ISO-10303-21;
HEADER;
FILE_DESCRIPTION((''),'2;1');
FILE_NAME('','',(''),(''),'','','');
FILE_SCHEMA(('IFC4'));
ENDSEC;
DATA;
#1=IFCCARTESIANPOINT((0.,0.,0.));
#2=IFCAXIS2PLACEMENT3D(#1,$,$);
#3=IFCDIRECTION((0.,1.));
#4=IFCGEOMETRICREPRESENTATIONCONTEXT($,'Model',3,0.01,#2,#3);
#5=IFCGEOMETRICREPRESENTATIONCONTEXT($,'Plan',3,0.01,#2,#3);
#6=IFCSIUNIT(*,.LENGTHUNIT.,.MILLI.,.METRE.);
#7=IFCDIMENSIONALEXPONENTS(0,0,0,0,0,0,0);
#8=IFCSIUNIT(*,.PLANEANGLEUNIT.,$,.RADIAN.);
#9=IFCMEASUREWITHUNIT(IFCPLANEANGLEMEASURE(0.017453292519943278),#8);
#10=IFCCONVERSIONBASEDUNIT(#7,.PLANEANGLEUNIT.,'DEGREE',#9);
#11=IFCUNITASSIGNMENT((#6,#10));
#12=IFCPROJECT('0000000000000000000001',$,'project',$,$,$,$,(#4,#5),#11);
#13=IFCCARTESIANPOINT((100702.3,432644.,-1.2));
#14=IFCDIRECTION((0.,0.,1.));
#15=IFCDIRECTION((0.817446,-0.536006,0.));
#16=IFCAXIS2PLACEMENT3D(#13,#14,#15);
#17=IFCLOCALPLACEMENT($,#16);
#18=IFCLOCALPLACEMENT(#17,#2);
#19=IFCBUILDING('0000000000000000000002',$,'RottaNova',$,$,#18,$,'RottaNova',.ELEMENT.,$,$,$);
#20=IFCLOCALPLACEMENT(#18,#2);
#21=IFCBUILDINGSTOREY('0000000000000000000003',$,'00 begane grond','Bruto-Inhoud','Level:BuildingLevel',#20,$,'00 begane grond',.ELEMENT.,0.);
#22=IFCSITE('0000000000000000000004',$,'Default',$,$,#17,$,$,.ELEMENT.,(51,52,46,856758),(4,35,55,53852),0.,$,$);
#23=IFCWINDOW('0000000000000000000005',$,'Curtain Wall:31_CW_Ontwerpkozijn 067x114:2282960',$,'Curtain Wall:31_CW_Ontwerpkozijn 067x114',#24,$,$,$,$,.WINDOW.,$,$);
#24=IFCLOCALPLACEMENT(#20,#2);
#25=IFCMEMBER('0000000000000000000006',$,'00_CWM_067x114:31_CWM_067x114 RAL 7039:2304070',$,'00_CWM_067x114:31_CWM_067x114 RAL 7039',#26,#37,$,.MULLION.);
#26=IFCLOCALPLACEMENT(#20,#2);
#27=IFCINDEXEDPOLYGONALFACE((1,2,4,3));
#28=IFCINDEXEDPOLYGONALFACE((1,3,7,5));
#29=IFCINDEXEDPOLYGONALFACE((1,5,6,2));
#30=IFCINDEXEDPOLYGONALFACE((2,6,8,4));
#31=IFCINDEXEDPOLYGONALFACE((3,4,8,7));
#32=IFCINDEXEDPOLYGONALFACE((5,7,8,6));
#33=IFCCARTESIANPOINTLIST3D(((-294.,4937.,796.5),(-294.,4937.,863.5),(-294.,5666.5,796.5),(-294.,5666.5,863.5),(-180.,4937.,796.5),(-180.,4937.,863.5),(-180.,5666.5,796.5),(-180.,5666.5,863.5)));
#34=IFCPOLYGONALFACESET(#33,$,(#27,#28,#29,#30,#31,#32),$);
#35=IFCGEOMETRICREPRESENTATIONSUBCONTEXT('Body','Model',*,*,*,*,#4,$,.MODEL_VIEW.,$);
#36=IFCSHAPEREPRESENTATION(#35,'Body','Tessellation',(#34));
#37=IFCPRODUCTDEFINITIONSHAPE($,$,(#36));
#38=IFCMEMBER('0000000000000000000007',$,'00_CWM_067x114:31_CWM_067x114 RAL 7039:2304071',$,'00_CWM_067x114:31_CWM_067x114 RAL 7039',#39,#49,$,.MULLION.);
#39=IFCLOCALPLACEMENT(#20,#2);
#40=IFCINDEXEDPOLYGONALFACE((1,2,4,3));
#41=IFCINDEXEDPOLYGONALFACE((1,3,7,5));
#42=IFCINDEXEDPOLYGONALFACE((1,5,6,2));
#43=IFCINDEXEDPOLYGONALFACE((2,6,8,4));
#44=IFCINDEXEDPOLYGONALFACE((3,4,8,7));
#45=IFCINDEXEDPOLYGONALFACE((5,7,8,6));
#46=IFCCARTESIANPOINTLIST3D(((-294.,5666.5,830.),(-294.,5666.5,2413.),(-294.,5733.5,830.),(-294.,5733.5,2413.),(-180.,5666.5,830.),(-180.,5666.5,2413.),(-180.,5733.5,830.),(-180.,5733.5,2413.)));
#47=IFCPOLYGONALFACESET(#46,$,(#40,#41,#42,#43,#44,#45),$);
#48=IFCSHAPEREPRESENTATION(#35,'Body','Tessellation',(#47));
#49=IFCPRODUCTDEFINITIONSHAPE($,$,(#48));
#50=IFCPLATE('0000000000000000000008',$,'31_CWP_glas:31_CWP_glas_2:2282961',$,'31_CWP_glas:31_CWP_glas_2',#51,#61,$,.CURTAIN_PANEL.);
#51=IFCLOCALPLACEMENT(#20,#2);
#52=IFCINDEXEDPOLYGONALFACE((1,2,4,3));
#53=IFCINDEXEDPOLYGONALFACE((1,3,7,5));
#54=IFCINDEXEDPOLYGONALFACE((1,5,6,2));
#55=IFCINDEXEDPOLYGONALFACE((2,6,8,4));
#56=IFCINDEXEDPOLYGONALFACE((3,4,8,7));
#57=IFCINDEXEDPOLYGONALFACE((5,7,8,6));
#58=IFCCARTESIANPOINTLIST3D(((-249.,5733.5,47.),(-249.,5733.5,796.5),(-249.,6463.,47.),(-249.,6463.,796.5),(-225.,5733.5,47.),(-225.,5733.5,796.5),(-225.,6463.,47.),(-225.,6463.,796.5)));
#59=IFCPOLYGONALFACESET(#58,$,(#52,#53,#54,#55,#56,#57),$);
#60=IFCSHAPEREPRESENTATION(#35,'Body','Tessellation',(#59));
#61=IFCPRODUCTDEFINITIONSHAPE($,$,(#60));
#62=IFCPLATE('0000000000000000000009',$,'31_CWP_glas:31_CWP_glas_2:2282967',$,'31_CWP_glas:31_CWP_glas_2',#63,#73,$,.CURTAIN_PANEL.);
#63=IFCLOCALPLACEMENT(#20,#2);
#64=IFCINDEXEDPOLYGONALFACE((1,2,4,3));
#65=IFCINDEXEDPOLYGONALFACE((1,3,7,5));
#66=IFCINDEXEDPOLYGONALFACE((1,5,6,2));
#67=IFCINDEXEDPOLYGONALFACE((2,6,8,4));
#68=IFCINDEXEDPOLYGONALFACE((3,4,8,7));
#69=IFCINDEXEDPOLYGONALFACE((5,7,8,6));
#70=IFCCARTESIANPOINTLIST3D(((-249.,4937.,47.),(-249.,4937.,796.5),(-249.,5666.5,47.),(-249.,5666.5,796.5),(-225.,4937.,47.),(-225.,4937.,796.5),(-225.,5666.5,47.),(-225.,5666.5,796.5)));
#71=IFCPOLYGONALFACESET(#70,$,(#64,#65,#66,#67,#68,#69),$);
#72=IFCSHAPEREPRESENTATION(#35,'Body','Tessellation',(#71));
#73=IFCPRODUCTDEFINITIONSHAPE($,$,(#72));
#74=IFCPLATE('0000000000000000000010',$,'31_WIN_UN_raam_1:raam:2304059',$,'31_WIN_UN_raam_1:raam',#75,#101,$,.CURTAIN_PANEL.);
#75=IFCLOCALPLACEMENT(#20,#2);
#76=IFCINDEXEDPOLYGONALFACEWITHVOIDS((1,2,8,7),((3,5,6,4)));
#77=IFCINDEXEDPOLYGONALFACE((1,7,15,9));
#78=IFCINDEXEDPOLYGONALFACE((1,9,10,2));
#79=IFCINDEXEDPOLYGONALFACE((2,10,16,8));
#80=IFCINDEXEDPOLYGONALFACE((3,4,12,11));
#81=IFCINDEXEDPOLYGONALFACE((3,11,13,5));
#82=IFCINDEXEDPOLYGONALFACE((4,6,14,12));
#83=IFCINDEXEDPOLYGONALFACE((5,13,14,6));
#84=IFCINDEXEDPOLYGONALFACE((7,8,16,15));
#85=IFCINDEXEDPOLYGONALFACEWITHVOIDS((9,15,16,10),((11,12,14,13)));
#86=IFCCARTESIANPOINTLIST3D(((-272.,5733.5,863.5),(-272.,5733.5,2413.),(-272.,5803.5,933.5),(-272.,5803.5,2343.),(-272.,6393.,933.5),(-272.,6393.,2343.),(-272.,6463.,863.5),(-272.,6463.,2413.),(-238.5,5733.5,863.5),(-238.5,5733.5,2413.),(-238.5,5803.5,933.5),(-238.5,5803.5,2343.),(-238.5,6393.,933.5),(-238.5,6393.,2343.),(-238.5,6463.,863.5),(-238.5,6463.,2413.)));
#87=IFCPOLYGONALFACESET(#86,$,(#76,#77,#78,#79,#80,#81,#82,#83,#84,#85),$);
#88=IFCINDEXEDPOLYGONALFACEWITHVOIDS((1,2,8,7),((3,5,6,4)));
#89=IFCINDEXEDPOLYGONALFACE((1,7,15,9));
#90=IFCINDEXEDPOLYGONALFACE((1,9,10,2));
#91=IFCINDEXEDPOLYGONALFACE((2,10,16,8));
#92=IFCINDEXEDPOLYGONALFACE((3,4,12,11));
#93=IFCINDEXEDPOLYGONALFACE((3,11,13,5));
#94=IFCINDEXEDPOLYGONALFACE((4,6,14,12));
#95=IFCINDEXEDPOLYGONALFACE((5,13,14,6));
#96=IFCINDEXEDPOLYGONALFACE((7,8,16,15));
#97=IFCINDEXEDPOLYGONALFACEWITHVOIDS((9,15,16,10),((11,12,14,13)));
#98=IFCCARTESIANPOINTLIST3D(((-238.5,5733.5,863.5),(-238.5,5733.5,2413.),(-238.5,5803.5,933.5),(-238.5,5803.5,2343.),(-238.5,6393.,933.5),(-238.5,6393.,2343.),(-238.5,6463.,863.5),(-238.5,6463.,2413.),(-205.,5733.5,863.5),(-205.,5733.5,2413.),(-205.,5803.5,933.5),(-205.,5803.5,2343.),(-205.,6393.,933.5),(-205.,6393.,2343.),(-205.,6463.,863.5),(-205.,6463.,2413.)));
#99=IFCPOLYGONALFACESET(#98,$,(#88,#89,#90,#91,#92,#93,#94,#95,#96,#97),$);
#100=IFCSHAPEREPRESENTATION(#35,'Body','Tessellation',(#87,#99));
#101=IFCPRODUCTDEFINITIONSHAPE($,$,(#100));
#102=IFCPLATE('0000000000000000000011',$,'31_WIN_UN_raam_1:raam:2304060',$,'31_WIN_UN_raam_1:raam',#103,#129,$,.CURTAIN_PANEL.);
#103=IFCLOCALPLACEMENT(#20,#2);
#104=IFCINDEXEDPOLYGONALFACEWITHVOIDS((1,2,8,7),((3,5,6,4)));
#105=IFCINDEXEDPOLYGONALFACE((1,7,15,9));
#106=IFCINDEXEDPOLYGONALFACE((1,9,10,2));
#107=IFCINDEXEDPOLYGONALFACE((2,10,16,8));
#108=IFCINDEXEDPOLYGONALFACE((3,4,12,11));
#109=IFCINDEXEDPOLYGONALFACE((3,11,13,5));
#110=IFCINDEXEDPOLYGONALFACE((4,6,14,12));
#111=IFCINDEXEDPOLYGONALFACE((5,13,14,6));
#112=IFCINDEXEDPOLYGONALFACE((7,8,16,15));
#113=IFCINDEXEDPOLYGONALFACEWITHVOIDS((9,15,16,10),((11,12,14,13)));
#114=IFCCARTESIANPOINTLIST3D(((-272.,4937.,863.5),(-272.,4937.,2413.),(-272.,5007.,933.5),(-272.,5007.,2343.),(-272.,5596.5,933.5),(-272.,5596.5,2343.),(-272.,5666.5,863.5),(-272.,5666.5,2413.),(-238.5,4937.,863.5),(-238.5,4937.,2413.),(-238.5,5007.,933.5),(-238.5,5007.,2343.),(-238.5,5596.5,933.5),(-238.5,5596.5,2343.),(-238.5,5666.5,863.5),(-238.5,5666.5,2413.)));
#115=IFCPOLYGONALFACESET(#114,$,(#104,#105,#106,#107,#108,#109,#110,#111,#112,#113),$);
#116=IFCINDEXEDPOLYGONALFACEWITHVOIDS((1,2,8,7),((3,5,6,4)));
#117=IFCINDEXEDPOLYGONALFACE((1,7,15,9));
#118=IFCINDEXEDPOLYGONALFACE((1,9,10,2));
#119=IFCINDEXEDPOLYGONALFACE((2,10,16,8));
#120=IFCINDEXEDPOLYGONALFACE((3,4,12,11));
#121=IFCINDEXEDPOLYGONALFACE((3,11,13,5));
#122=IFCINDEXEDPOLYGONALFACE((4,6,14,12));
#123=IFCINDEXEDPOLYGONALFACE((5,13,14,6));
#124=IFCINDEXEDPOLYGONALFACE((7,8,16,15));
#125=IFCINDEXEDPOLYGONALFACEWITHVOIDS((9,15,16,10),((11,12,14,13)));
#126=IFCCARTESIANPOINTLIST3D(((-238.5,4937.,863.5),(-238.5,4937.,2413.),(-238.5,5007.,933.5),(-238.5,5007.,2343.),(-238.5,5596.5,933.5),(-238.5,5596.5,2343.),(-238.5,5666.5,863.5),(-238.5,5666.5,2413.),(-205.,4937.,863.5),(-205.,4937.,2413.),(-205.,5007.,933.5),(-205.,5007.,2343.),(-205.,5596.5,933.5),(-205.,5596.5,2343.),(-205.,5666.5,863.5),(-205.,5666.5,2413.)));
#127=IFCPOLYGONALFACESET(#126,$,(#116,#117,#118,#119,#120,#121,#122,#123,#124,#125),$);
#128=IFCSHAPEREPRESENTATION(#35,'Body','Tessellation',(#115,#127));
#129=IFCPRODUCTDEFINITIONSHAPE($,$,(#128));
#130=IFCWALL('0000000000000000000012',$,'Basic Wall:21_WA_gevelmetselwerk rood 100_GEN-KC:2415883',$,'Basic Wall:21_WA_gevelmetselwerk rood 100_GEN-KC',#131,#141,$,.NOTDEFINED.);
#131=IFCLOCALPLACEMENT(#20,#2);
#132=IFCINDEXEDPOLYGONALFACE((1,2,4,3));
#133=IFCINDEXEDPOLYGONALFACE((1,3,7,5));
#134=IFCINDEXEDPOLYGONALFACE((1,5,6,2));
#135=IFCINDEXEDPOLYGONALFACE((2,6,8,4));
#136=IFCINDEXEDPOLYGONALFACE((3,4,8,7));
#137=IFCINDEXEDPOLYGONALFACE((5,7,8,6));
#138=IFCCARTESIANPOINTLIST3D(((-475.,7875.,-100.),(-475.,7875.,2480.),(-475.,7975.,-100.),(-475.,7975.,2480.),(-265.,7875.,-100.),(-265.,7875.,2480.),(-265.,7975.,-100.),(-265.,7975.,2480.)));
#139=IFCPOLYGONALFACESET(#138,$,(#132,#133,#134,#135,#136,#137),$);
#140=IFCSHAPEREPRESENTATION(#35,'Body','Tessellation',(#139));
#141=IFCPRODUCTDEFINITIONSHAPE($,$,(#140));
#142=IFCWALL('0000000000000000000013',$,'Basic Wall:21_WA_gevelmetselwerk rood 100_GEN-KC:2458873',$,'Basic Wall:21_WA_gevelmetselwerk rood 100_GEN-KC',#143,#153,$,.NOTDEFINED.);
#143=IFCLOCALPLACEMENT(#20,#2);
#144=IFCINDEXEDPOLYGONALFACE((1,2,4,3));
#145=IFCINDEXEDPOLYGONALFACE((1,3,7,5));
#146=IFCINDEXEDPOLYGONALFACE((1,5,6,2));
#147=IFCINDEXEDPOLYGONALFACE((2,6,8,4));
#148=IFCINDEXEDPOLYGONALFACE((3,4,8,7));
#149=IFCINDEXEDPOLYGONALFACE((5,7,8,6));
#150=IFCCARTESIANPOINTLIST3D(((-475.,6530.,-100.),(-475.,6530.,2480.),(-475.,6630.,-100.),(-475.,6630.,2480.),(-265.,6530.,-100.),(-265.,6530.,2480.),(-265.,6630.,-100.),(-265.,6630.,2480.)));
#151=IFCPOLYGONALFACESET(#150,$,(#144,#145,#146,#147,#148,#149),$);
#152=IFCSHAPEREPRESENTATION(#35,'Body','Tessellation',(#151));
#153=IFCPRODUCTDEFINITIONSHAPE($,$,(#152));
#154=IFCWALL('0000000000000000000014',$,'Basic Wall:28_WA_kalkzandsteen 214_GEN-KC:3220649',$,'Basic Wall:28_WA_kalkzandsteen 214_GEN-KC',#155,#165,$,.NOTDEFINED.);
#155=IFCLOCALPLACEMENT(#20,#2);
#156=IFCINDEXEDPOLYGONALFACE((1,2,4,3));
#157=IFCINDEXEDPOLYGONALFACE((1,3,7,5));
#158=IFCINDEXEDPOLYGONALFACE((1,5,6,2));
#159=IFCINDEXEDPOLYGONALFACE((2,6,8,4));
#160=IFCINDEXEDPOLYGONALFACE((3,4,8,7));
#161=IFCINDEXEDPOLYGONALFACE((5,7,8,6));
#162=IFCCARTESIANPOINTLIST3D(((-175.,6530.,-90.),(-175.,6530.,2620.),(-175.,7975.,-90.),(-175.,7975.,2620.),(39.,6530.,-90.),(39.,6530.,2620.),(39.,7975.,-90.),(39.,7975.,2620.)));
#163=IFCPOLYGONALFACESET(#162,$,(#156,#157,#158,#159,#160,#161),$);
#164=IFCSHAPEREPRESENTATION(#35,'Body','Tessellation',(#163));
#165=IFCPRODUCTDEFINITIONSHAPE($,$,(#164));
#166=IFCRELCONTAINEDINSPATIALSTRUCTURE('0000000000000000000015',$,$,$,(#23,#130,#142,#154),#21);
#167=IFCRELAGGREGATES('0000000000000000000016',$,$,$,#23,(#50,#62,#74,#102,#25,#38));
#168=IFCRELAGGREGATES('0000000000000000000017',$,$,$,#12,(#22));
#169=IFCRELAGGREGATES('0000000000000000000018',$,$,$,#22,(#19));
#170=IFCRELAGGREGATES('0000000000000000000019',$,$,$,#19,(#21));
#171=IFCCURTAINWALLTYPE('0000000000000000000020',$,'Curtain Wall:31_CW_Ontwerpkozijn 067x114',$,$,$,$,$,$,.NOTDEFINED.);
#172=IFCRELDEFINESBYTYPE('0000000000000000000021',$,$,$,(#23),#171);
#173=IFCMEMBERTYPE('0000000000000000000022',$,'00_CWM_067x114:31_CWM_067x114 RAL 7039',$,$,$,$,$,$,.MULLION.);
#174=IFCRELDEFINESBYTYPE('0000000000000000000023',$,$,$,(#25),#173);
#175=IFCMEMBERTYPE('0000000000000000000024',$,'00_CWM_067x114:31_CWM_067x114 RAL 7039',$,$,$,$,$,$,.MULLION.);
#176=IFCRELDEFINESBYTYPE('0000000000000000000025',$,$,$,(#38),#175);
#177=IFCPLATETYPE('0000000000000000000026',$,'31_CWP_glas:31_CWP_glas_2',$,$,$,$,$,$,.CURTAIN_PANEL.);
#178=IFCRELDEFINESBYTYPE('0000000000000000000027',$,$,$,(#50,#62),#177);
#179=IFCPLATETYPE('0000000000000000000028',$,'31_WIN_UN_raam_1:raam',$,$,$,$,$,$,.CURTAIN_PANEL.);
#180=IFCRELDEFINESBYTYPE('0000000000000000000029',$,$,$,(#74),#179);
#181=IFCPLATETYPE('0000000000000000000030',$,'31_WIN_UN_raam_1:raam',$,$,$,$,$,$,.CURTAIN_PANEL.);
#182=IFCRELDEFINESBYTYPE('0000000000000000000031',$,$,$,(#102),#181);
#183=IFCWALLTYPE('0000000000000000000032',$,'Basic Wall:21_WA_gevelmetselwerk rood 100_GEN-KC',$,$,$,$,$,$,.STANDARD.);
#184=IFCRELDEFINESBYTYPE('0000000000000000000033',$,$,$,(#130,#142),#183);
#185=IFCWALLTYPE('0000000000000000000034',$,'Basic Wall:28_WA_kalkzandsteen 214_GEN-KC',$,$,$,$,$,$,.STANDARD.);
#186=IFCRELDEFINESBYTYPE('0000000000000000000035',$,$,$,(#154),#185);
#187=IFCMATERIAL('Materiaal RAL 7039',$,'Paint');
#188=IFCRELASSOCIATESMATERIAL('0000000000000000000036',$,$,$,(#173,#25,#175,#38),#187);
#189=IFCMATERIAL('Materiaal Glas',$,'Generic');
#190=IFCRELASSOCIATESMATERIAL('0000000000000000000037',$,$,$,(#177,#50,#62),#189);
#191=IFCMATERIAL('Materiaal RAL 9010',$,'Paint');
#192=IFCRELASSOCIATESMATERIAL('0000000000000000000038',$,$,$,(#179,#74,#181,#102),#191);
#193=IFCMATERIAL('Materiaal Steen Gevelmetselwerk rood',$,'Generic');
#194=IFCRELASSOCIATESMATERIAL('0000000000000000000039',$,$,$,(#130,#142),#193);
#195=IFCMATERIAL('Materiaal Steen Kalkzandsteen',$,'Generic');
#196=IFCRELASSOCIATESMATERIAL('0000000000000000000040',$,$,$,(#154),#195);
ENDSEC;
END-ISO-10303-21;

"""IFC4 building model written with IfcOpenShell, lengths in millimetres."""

from ifc_helpers import new_model, entity, si_unit, converted_unit, direction, frame, origin, place, context, subcontext, project, spatial, indexed_curve, outline, extrude, source, transform, mapped, material, type_object, type_shapes, element, aggregate, save


model = new_model("IFC4")

# Units and contexts
model_context = context("Model", 3, precision=0.01, world=origin(), true_north=direction((0.0, 1.0)))
plan_context = context("Plan", 3, precision=0.01, world=origin(), true_north=direction((0.0, 1.0)))
body_context = subcontext(model_context, "Body", "Model", "MODEL_VIEW")
ifc_project = project(units=[si_unit("LENGTHUNIT", "METRE", prefix="MILLI"), converted_unit("PLANEANGLEUNIT", "DEGREE", entity("IfcPlaneAngleMeasure", 0.017453292519943278), si_unit("PLANEANGLEUNIT", "RADIAN"), dimensions=[0, 0, 0, 0, 0, 0, 0])], contexts=[model_context, plan_context])

# Site, building, storey
site_placement = place(None, frame((100702.3, 432644.0, -1.2), z_axis=(0.0, 0.0, 1.0), x_axis=(0.817446, -0.536006, 0.0)))
site = spatial("IfcSite", under=ifc_project, at=site_placement, Name="Default", CompositionType="ELEMENT", RefLatitude=(51, 52, 46, 856758), RefLongitude=(4, 35, 55, 53852), RefElevation=0.0)
building_placement = place(site_placement, origin())
building = spatial("IfcBuilding", under=site, at=building_placement, Name="RottaNova", LongName="RottaNova", CompositionType="ELEMENT")
storey_placement = place(building_placement, origin())
storey = spatial("IfcBuildingStorey", under=building, at=storey_placement, Name="00 begane grond", Description="Bruto-Inhoud", ObjectType="Level:BuildingLevel", LongName="00 begane grond", CompositionType="ELEMENT", Elevation=0.0)

# Window, members, plates
curtain_wall_type = type_object("IfcCurtainWallType", Name="Curtain Wall:31_CW_Ontwerpkozijn 067x114", PredefinedType="NOTDEFINED")
window_placement = place(storey_placement, origin())
window = element("IfcWindow", 1, at=window_placement, inside=storey, type_object=curtain_wall_type, Name="Curtain Wall:31_CW_Ontwerpkozijn 067x114:2282960", ObjectType="Curtain Wall:31_CW_Ontwerpkozijn 067x114", PredefinedType="WINDOW")
ifc_material_1 = material(Name="Materiaal RAL 7039", Category="Paint")
member_type_1 = type_object("IfcMemberType", Name="00_CWM_067x114:31_CWM_067x114 RAL 7039", PredefinedType="MULLION", material=ifc_material_1)
shared_shape_1 = source(origin(), body_context, "Body", "SweptSolid", [
    extrude(outline(indexed_curve([(-33.5, -57.0), (33.5, -57.0), (33.5, 57.0), (-33.5, 57.0), (-33.5, -57.0)], self_intersect=False)), frame((0.0, 57.0, -729.5), z_axis=(0.0, 0.0, 1.0), x_axis=(-1.0, 0.0, 0.0)), (0.0, 0.0, 1.0), 729.5),
])
type_shapes(member_type_1, [shared_shape_1])
member_1_placement = place(window_placement, frame((-180.0, 4937.0, 830.0), z_axis=(0.0, -1.0, 0.0), x_axis=(0.0, 0.0, 1.0)))
member_1 = element("IfcMember", 2, at=member_1_placement, type_object=member_type_1, material=ifc_material_1, Name="00_CWM_067x114:31_CWM_067x114 RAL 7039:2304070", ObjectType="00_CWM_067x114:31_CWM_067x114 RAL 7039", PredefinedType="MULLION", context=body_context, shape_type="MappedRepresentation", body=[
    mapped(shared_shape_1, transform((0.0, 0.0, 0.0), scale=1.0)),
])
member_type_2 = type_object("IfcMemberType", Name="00_CWM_067x114:31_CWM_067x114 RAL 7039", PredefinedType="MULLION", material=ifc_material_1)
shared_shape_2 = source(origin(), body_context, "Body", "SweptSolid", [
    extrude(outline(indexed_curve([(-33.5, -57.0), (33.5, -57.0), (33.5, 57.0), (-33.5, 57.0), (-33.5, -57.0)], self_intersect=False)), frame((0.0, 57.0, -1583.0), z_axis=(0.0, 0.0, 1.0), x_axis=(-1.0, 0.0, 0.0)), (0.0, 0.0, 1.0), 1583.0),
])
type_shapes(member_type_2, [shared_shape_2])
member_2_placement = place(window_placement, frame((-180.0, 5700.0, 830.0), z_axis=(0.0, 0.0, -1.0), x_axis=(0.0, -1.0, 0.0)))
member_2 = element("IfcMember", 3, at=member_2_placement, type_object=member_type_2, material=ifc_material_1, Name="00_CWM_067x114:31_CWM_067x114 RAL 7039:2304071", ObjectType="00_CWM_067x114:31_CWM_067x114 RAL 7039", PredefinedType="MULLION", context=body_context, shape_type="MappedRepresentation", body=[
    mapped(shared_shape_2, transform((0.0, 0.0, 0.0), scale=1.0)),
])
ifc_material_2 = material(Name="Materiaal Glas", Category="Generic")
plate_type_1 = type_object("IfcPlateType", Name="31_CWP_glas:31_CWP_glas_2", PredefinedType="CURTAIN_PANEL", material=ifc_material_2)
shared_shape_3 = source(origin(), body_context, "Body", "SweptSolid", [
    extrude(outline(indexed_curve([(-12.0, -364.7), (12.0, -364.7), (12.0, 364.7), (-12.0, 364.7), (-12.0, -364.7)], self_intersect=False)), frame((0.0, -57.0, 0.0), z_axis=(0.0, 0.0, 1.0), x_axis=(0.0, 1.0, 0.0)), (0.0, 0.0, 1.0), 749.5),
])
type_shapes(plate_type_1, [shared_shape_3])
plate_1_placement = place(window_placement, frame((-180.0, 6098.2, 47.0), z_axis=(0.0, 0.0, 1.0), x_axis=(0.0, -1.0, 0.0)))
plate_1 = element("IfcPlate", 4, at=plate_1_placement, type_object=plate_type_1, material=ifc_material_2, Name="31_CWP_glas:31_CWP_glas_2:2282961", ObjectType="31_CWP_glas:31_CWP_glas_2", PredefinedType="CURTAIN_PANEL", context=body_context, shape_type="MappedRepresentation", body=[
    mapped(shared_shape_3, transform((0.0, 0.0, 0.0), scale=1.0)),
])
plate_2_placement = place(window_placement, frame((-180.0, 5301.7, 47.0), z_axis=(0.0, 0.0, 1.0), x_axis=(0.0, -1.0, 0.0)))
plate_2 = element("IfcPlate", 5, at=plate_2_placement, type_object=plate_type_1, material=ifc_material_2, Name="31_CWP_glas:31_CWP_glas_2:2282967", ObjectType="31_CWP_glas:31_CWP_glas_2", PredefinedType="CURTAIN_PANEL", context=body_context, shape_type="MappedRepresentation", body=[
    mapped(shared_shape_3, transform((0.0, 0.0, 0.0), scale=1.0)),
])
ifc_material_3 = material(Name="Materiaal RAL 9010", Category="Paint")
plate_type_2 = type_object("IfcPlateType", Name="31_WIN_UN_raam_1:raam", PredefinedType="CURTAIN_PANEL", material=ifc_material_3)
shared_shape_4 = source(origin(), body_context, "Body", "SweptSolid", [
    extrude(outline(indexed_curve([(-364.7, -774.7), (364.7, -774.7), (364.7, 774.7), (-364.7, 774.7), (-364.7, -774.7)], self_intersect=False), holes=[indexed_curve([(-294.7, 704.7), (294.7, 704.7), (294.7, -704.8), (-294.7, -704.8), (-294.7, 704.7)], self_intersect=False)]), frame((0.0, -92.0, 774.8), z_axis=(0.0, 1.0, 0.0), x_axis=(1.0, 0.0, 0.0)), (0.0, 0.0, 1.0), 33.5),
    extrude(outline(indexed_curve([(-364.7, -774.7), (364.7, -774.7), (364.7, 774.7), (-364.7, 774.7), (-364.7, -774.7)], self_intersect=False), holes=[indexed_curve([(-294.7, 704.7), (294.7, 704.7), (294.7, -704.8), (-294.7, -704.8), (-294.7, 704.7)], self_intersect=False)]), frame((0.0, -58.5, 774.8), z_axis=(0.0, 1.0, 0.0), x_axis=(1.0, 0.0, 0.0)), (0.0, 0.0, 1.0), 33.5),
])
type_shapes(plate_type_2, [shared_shape_4])
plate_3_placement = place(window_placement, frame((-180.0, 6098.2, 863.5), z_axis=(0.0, 0.0, 1.0), x_axis=(0.0, -1.0, 0.0)))
plate_3 = element("IfcPlate", 6, at=plate_3_placement, type_object=plate_type_2, material=ifc_material_3, Name="31_WIN_UN_raam_1:raam:2304059", ObjectType="31_WIN_UN_raam_1:raam", PredefinedType="CURTAIN_PANEL", context=body_context, shape_type="MappedRepresentation", body=[
    mapped(shared_shape_4, transform((0.0, 0.0, 0.0), scale=1.0)),
])
plate_type_3 = type_object("IfcPlateType", Name="31_WIN_UN_raam_1:raam", PredefinedType="CURTAIN_PANEL", material=ifc_material_3)
shared_shape_5 = source(origin(), body_context, "Body", "SweptSolid", [
    extrude(outline(indexed_curve([(-364.7, -774.7), (364.7, -774.7), (364.7, 774.7), (-364.7, 774.7), (-364.7, -774.7)], self_intersect=False), holes=[indexed_curve([(-294.7, 704.7), (294.7, 704.7), (294.7, -704.8), (-294.7, -704.8), (-294.7, 704.7)], self_intersect=False)]), frame((0.0, -92.0, 774.8), z_axis=(0.0, 1.0, 0.0), x_axis=(1.0, 0.0, 0.0)), (0.0, 0.0, 1.0), 33.5),
    extrude(outline(indexed_curve([(-364.7, -774.7), (364.7, -774.7), (364.7, 774.7), (-364.7, 774.7), (-364.7, -774.7)], self_intersect=False), holes=[indexed_curve([(-294.7, 704.7), (294.7, 704.7), (294.7, -704.8), (-294.7, -704.8), (-294.7, 704.7)], self_intersect=False)]), frame((0.0, -58.5, 774.8), z_axis=(0.0, 1.0, 0.0), x_axis=(1.0, 0.0, 0.0)), (0.0, 0.0, 1.0), 33.5),
])
type_shapes(plate_type_3, [shared_shape_5])
plate_4_placement = place(window_placement, frame((-180.0, 5301.7, 863.5), z_axis=(0.0, 0.0, 1.0), x_axis=(0.0, -1.0, 0.0)))
plate_4 = element("IfcPlate", 7, at=plate_4_placement, type_object=plate_type_3, material=ifc_material_3, Name="31_WIN_UN_raam_1:raam:2304060", ObjectType="31_WIN_UN_raam_1:raam", PredefinedType="CURTAIN_PANEL", context=body_context, shape_type="MappedRepresentation", body=[
    mapped(shared_shape_5, transform((0.0, 0.0, 0.0), scale=1.0)),
])
aggregate(window, [plate_1, plate_2, plate_3, plate_4, member_1, member_2])

# Walls
ifc_material_4 = material(Name="Materiaal Steen Gevelmetselwerk rood", Category="Generic")
wall_type_1 = type_object("IfcWallType", Name="Basic Wall:21_WA_gevelmetselwerk rood 100_GEN-KC", PredefinedType="STANDARD")
wall_1_placement = place(storey_placement, frame((-475.0, 7925.0, -100.0)))
element("IfcWall", 8, at=wall_1_placement, inside=storey, type_object=wall_type_1, material=ifc_material_4, Name="Basic Wall:21_WA_gevelmetselwerk rood 100_GEN-KC:2415883", ObjectType="Basic Wall:21_WA_gevelmetselwerk rood 100_GEN-KC", PredefinedType="NOTDEFINED", context=body_context, shape_type="SweptSolid", body=[
    extrude(outline(indexed_curve([(210.0, 50.0), (0.0, 50.0), (0.0, -50.0), (210.0, -50.0), (210.0, 50.0)], self_intersect=False)), origin(), (0.0, 0.0, 1.0), 2580.0),
])
wall_2_placement = place(storey_placement, frame((-475.0, 6580.0, -100.0)))
element("IfcWall", 9, at=wall_2_placement, inside=storey, type_object=wall_type_1, material=ifc_material_4, Name="Basic Wall:21_WA_gevelmetselwerk rood 100_GEN-KC:2458873", ObjectType="Basic Wall:21_WA_gevelmetselwerk rood 100_GEN-KC", PredefinedType="NOTDEFINED", context=body_context, shape_type="SweptSolid", body=[
    extrude(outline(indexed_curve([(210.0, 50.0), (0.0, 50.0), (0.0, -50.0), (210.0, -50.0), (210.0, 50.0)], self_intersect=False)), origin(), (0.0, 0.0, 1.0), 2580.0),
])
ifc_material_5 = material(Name="Materiaal Steen Kalkzandsteen", Category="Generic")
wall_type_2 = type_object("IfcWallType", Name="Basic Wall:28_WA_kalkzandsteen 214_GEN-KC", PredefinedType="STANDARD")
wall_3_placement = place(storey_placement, frame((-68.0, 6530.0, -90.0), z_axis=(0.0, 0.0, 1.0), x_axis=(0.0, 1.0, 0.0)))
element("IfcWall", 10, at=wall_3_placement, inside=storey, type_object=wall_type_2, material=ifc_material_5, Name="Basic Wall:28_WA_kalkzandsteen 214_GEN-KC:3220649", ObjectType="Basic Wall:28_WA_kalkzandsteen 214_GEN-KC", PredefinedType="NOTDEFINED", context=body_context, shape_type="SweptSolid", body=[
    extrude(outline(indexed_curve([(1445.0, 107.0), (0.0, 107.0), (0.0, -107.0), (1445.0, -107.0), (1445.0, 107.0)], self_intersect=False)), origin(), (0.0, 0.0, 1.0), 2710.0),
])

save(model, "model.ifc")
